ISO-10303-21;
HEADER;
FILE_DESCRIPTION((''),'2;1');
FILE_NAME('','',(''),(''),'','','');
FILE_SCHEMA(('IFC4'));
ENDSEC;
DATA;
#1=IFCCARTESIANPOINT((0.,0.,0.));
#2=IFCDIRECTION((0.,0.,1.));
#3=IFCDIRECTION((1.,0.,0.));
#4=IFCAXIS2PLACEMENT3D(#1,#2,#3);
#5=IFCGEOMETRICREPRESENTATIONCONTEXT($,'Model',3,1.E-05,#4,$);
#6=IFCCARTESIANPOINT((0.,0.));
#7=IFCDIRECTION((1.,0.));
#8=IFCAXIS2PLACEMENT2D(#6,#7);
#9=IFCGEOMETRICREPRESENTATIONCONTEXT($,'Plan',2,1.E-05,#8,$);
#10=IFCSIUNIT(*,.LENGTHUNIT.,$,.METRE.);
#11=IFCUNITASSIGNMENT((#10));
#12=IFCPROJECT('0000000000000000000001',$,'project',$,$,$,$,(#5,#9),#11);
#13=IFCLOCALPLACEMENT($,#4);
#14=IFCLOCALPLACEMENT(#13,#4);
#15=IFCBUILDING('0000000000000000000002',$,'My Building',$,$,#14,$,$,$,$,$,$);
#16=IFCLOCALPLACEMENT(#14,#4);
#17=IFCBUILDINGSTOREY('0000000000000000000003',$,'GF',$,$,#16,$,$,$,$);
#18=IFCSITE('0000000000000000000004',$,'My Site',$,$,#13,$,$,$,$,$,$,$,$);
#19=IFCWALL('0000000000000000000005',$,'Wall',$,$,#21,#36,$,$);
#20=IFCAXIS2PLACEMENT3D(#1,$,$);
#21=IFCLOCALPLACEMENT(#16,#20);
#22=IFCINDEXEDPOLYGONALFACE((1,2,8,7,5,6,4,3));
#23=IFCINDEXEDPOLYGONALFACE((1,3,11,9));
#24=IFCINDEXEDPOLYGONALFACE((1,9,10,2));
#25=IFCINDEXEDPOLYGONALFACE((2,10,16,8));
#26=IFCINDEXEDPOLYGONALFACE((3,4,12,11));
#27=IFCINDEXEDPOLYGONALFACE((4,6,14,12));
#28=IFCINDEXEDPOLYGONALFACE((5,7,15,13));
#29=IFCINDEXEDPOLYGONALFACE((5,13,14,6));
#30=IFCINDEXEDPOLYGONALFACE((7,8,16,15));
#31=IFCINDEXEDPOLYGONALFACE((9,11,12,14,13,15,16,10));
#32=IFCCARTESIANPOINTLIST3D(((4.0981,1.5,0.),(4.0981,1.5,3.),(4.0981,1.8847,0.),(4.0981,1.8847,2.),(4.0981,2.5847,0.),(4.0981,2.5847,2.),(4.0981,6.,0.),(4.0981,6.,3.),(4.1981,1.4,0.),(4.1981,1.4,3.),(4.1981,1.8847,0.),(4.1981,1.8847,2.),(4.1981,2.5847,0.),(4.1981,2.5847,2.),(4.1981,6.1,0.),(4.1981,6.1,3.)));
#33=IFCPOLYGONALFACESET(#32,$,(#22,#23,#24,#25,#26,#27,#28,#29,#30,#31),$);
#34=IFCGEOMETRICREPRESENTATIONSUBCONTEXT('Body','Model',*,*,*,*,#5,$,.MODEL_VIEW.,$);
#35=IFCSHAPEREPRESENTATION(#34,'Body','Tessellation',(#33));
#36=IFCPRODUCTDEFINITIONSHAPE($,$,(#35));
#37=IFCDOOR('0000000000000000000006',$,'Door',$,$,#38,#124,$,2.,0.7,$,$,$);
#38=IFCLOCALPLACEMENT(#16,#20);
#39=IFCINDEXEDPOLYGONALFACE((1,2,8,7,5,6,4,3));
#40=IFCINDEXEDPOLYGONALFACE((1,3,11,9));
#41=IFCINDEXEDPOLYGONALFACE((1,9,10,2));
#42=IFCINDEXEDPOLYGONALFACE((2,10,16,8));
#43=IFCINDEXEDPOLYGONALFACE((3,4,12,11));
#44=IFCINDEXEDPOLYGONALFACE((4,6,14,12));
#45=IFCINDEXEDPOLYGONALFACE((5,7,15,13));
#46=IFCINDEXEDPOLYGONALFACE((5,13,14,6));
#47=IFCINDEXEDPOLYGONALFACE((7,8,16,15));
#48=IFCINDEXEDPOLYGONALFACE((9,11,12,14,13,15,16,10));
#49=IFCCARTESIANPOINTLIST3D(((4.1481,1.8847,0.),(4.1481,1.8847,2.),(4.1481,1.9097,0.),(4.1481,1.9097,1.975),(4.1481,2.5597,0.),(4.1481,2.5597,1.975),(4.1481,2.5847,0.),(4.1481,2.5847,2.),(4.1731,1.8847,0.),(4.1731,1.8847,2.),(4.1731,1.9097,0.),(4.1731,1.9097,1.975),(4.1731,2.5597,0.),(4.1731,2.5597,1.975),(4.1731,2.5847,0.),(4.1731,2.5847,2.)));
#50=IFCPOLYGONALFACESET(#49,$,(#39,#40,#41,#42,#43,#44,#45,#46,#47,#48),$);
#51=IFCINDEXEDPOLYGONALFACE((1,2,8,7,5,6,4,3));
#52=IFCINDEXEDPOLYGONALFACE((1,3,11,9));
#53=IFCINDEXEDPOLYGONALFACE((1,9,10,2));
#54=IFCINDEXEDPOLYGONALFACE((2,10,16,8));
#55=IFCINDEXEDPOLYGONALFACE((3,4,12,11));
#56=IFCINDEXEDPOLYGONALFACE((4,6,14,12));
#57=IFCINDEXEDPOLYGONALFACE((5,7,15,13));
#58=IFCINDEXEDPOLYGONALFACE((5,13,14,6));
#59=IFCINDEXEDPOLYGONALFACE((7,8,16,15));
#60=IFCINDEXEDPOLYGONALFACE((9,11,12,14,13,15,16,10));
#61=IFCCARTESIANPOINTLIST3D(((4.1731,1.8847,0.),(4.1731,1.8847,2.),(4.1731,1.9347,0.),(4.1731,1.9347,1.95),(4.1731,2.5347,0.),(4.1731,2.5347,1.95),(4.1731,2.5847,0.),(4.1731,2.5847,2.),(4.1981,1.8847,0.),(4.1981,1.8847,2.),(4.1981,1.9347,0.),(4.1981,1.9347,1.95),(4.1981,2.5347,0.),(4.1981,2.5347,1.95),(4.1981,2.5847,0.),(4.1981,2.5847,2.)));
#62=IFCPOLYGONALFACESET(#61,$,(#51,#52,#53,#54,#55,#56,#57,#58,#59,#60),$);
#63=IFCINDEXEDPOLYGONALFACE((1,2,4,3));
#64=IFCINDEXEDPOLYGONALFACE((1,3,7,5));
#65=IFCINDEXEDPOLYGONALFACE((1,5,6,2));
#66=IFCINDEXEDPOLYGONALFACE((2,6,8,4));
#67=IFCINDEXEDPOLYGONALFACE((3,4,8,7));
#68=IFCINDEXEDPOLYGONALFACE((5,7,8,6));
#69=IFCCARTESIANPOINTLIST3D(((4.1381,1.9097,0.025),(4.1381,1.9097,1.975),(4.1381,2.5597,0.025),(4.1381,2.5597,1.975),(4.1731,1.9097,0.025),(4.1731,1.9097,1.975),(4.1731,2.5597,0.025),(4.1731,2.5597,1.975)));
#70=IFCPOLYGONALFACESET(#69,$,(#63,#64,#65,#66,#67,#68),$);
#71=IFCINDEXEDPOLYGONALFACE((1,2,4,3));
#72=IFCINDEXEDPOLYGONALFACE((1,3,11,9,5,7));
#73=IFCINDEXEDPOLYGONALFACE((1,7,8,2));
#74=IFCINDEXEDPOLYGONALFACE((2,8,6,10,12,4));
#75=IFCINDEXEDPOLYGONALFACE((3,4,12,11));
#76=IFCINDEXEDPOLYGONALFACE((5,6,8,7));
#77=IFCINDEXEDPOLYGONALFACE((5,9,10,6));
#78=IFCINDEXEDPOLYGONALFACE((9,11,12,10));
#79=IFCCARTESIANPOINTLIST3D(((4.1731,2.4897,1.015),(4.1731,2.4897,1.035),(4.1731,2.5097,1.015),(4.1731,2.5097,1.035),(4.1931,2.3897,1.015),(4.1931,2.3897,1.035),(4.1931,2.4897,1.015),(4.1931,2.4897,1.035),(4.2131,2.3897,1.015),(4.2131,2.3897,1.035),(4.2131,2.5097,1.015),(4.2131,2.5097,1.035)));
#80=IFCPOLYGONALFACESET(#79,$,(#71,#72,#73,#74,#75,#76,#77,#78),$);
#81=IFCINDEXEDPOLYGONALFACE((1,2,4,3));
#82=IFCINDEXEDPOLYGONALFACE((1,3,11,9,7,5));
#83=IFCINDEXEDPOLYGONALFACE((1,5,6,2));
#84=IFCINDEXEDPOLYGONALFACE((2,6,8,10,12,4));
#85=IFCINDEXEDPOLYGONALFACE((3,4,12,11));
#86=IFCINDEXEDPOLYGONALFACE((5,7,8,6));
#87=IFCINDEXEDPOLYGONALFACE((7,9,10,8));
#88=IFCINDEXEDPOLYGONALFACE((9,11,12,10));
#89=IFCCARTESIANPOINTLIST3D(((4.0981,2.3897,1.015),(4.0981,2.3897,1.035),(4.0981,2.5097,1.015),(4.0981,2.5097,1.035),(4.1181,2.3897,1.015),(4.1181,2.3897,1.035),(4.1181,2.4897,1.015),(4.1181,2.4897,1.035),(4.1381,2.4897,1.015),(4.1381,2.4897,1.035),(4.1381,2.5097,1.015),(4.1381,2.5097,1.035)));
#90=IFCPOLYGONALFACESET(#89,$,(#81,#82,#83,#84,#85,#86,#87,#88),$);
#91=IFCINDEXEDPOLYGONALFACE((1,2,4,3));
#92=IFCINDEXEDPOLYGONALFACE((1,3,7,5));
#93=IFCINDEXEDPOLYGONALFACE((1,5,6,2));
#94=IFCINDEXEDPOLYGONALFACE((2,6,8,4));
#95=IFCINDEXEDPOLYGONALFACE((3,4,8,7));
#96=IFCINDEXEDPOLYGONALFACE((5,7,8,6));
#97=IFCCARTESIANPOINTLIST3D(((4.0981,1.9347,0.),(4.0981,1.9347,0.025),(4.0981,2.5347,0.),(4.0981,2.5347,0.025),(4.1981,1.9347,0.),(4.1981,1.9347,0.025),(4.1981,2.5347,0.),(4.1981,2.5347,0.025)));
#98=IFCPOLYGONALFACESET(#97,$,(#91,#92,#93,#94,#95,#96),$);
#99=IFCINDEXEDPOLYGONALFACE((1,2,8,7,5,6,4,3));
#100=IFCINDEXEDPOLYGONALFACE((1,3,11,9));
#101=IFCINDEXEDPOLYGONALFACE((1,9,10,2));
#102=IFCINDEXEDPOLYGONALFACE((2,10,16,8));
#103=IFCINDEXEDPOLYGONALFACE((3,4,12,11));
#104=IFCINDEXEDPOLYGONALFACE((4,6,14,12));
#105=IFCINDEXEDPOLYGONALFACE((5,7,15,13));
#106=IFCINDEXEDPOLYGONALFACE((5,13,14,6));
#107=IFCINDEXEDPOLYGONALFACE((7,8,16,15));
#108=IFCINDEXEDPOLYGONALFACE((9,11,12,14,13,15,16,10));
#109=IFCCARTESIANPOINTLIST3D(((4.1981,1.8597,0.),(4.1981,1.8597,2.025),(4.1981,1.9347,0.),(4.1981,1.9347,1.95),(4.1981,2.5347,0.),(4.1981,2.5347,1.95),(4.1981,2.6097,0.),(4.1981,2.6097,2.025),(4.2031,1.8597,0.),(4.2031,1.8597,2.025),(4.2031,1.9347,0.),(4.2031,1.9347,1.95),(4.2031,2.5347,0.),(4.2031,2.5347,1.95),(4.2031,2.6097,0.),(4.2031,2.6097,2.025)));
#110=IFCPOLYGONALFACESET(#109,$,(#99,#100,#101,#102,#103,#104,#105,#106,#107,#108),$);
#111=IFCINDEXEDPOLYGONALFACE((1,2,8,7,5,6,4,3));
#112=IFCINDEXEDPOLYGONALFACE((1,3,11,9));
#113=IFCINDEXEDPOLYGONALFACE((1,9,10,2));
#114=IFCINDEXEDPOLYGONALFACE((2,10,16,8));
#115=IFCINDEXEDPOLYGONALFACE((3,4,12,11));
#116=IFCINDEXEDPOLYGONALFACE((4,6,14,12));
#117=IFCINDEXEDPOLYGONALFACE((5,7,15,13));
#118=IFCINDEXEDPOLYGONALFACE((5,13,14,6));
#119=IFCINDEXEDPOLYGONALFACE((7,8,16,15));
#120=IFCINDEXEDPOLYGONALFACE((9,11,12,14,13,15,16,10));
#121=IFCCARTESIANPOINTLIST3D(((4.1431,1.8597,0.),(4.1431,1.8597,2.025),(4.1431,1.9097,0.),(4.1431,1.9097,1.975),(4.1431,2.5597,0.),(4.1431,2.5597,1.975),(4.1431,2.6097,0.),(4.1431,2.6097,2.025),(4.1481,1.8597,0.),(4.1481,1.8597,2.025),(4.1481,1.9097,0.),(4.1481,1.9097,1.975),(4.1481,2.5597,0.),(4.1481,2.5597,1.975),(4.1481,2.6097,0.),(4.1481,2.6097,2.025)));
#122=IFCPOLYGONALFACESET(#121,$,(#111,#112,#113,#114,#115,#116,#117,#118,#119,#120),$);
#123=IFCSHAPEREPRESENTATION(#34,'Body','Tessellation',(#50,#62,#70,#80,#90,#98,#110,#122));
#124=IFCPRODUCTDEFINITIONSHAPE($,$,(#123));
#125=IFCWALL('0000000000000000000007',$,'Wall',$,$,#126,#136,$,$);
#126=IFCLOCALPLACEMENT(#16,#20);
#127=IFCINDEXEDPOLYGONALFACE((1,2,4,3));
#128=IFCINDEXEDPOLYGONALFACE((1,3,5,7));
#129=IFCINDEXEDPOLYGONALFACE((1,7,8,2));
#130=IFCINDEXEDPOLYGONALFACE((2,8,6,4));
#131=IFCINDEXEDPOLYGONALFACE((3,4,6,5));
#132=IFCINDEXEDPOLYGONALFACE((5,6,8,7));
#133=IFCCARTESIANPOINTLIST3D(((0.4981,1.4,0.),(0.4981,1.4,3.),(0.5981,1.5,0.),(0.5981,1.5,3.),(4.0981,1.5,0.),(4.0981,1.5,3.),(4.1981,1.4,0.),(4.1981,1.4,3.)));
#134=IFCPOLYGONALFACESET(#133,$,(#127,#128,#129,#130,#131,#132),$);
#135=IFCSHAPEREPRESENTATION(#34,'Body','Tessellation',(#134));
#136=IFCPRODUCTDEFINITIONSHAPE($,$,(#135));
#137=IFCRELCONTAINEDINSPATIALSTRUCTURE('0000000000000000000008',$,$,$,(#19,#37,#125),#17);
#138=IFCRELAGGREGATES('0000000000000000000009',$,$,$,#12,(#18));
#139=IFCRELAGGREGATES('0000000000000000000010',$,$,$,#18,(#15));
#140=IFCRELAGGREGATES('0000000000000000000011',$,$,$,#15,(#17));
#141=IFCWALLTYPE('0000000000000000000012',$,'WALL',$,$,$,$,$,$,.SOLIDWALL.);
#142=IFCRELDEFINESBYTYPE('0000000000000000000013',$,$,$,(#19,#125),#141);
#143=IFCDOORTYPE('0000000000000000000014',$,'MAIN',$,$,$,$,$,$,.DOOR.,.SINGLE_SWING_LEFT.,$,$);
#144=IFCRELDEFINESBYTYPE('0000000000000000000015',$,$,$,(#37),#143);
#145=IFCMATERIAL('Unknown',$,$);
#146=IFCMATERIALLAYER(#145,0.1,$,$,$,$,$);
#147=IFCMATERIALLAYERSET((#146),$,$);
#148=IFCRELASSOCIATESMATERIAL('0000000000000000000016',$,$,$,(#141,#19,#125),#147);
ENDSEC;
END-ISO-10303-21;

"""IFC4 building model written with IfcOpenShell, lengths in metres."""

from ifc_helpers import new_model, entity, si_unit, frame, origin_with_axes, origin_2d_with_axis, place, context, subcontext, project, spatial, line, indexed_curve, outline, extrude, shape, source, transform, mapped, material, layer, layer_set, layer_usage, type_object, type_shapes, element, fill, save


model = new_model("IFC4")

# Units and contexts
model_context = context("Model", 3, precision=1e-05, world=origin_with_axes())
plan_context = context("Plan", 2, precision=1e-05, world=origin_2d_with_axis())
body_context_1 = subcontext(model_context, "Body", "Model", "MODEL_VIEW")
body_context_2 = subcontext(plan_context, "Body", "Plan", "PLAN_VIEW")
ifc_project = project(units=[si_unit("LENGTHUNIT", "METRE")], contexts=[model_context, plan_context])

# Site, building, storey
site_placement = place(None, origin_with_axes())
site = spatial("IfcSite", under=ifc_project, at=site_placement, Name="My Site")
building_placement = place(site_placement, origin_with_axes())
building = spatial("IfcBuilding", under=site, at=building_placement, Name="My Building")
storey_placement = place(building_placement, origin_with_axes())
storey = spatial("IfcBuildingStorey", under=building, at=storey_placement, Name="GF")

# Shared definitions
ifc_material = material(Name="Unknown")

# Shared definitions
ifc_layer_1 = layer(ifc_material, 0.1)
ifc_layer_set_1 = layer_set([ifc_layer_1])
wall_type_1 = type_object("IfcWallType", Name="WALL", PredefinedType="SOLIDWALL", material=ifc_layer_set_1)

# Wall, opening, door
ifc_layer_usage_1 = layer_usage(ifc_layer_set_1, "AXIS2", "POSITIVE", 0.0)
wall_1_placement = place(storey_placement, frame((4.0981, 6.0, 0.0), z_axis=(0.0, 0.0, 1.0), x_axis=(0.0, -1.0, 0.0)))
wall_1 = element("IfcWall", 1, at=wall_1_placement, inside=storey, type_object=wall_type_1, material=ifc_layer_usage_1, Name="Wall", context=body_context_1, shape_type="SweptSolid", body=[
    extrude(outline(indexed_curve([(0.0, 0.0), (-0.1, 0.1), (4.6, 0.1), (4.5, 0.0)], segments=[line(1, 2, 3, 4, 1)])), origin_with_axes(), (0.0, 0.0, 1.0), 3.0),
])
shared_shape_1 = source(origin_with_axes(), body_context_1, "Body", "SweptSolid", [
    extrude(outline(indexed_curve([(0.0, 0.0), (0.7, 0.0), (0.7, 2.0), (0.0, 2.0)], segments=[line(1, 2, 3, 4, 1)])), frame((0.0, -0.6, 0.0), z_axis=(0.0, -1.0, 0.0), x_axis=(1.0, 0.0, 0.0)), (0.0, 0.0, -1.0), 1.2),
])
opening_1_placement = place(wall_1_placement, frame((4.1153, 0.1, 0.0), z_axis=(0.0, 0.0, 1.0), x_axis=(-1.0, 0.0, 0.0)))
opening_1 = element("IfcOpeningElement", 2, at=opening_1_placement, cuts=wall_1, PredefinedType="OPENING", context=body_context_1, shape_type="MappedRepresentation", body=[
    mapped(shared_shape_1, transform((0.0, 0.0, 0.0), x_axis=(1.0, 0.0, 0.0), y_axis=(0.0, 1.0, 0.0), z_axis=(0.0, 0.0, 1.0), scale=1.0)),
])
door_type_1 = type_object("IfcDoorType", Name="MAIN", OperationType="SINGLE_SWING_LEFT", PredefinedType="DOOR")
shared_shape_2 = source(origin_with_axes(), body_context_1, "Body", "SweptSolid", [
    extrude(outline(indexed_curve([(0.0, 0.0), (0.0, 2.0), (0.7, 2.0), (0.7, 0.0), (0.675, 0.0), (0.675, 1.975), (0.025, 1.975), (0.025, 0.0)], segments=[line(1, 2, 3, 4, 5, 6, 7, 8, 1)])), frame((0.0, 0.025, 0.0), z_axis=(0.0, -1.0, 0.0), x_axis=(1.0, 0.0, 0.0)), (0.0, 0.0, -1.0), 0.025),
    extrude(outline(indexed_curve([(0.0, 0.0), (0.0, 2.0), (0.7, 2.0), (0.7, 0.0), (0.65, 0.0), (0.65, 1.95), (0.05, 1.95), (0.05, 0.0)], segments=[line(1, 2, 3, 4, 5, 6, 7, 8, 1)])), frame((0.0, 0.0, 0.0), z_axis=(0.0, -1.0, 0.0), x_axis=(1.0, 0.0, 0.0)), (0.0, 0.0, -1.0), 0.025),
    extrude(outline(indexed_curve([(0.0, 0.0), (0.65, 0.0), (0.65, 0.035), (0.0, 0.035)], segments=[line(1, 2, 3, 4, 1)])), frame((0.025, 0.025, 0.025), z_axis=(0.0, 0.0, 1.0), x_axis=(1.0, 0.0, 0.0)), (0.0, 0.0, 1.0), 1.95),
    extrude(outline(indexed_curve([(0.0, 0.0), (0.0, -0.04), (-0.12, -0.04), (-0.12, -0.02), (-0.02, -0.02), (-0.02, 0.0)], segments=[line(1, 2, 3, 4, 5, 6, 1)])), frame((0.625, 0.025, 1.015), z_axis=(0.0, 0.0, 1.0), x_axis=(1.0, 0.0, 0.0)), (0.0, 0.0, 1.0), 0.02),
    extrude(outline(indexed_curve([(0.0, 0.0), (0.0, 0.04), (-0.12, 0.04), (-0.12, 0.02), (-0.02, 0.02), (-0.02, 0.0)], segments=[line(1, 2, 3, 4, 5, 6, 1)])), frame((0.625, 0.06, 1.015), z_axis=(0.0, 0.0, 1.0), x_axis=(1.0, 0.0, 0.0)), (0.0, 0.0, 1.0), 0.02),
    extrude(outline(indexed_curve([(0.0, 0.0), (0.6, 0.0), (0.6, 0.1), (0.0, 0.1)], segments=[line(1, 2, 3, 4, 1)])), frame((0.05, 0.0, 0.0), z_axis=(0.0, 0.0, 1.0), x_axis=(1.0, 0.0, 0.0)), (0.0, 0.0, 1.0), 0.025),
    extrude(outline(indexed_curve([(0.0, 0.0), (0.0, 2.025), (0.75, 2.025), (0.75, 0.0), (0.675, 0.0), (0.675, 1.95), (0.075, 1.95), (0.075, 0.0)], segments=[line(1, 2, 3, 4, 5, 6, 7, 8, 1)])), frame((-0.025, -0.005, 0.0), z_axis=(0.0, -1.0, 0.0), x_axis=(1.0, 0.0, 0.0)), (0.0, 0.0, -1.0), 0.005),
    extrude(outline(indexed_curve([(0.0, 0.0), (0.0, 2.025), (0.75, 2.025), (0.75, 0.0), (0.7, 0.0), (0.7, 1.975), (0.05, 1.975), (0.05, 0.0)], segments=[line(1, 2, 3, 4, 5, 6, 7, 8, 1)])), frame((-0.025, 0.05, 0.0), z_axis=(0.0, -1.0, 0.0), x_axis=(1.0, 0.0, 0.0)), (0.0, 0.0, -1.0), 0.005),
])
shared_shape_3 = source(origin_with_axes(), body_context_2, "Body", "Curve2D", [
    entity("IfcIndexedPolyCurve", entity("IfcCartesianPointList2D", [[0.0, 0.0], [0.0, 0.05], [0.025, 0.05], [0.025, 0.025], [0.05, 0.025], [0.05, 0.0]]), [entity("IfcLineIndex", [1, 2, 3, 4, 5, 6, 1])]),
    entity("IfcIndexedPolyCurve", entity("IfcCartesianPointList2D", [[0.7, 0.0], [0.7, 0.05], [0.675, 0.05], [0.675, 0.025], [0.65, 0.025], [0.65, 0.0]]), [entity("IfcLineIndex", [1, 2, 3, 4, 5, 6, 1])]),
    entity("IfcTrimmedCurve", entity("IfcEllipse", entity("IfcAxis2Placement2D", entity("IfcCartesianPoint", [0.06, 0.05]), entity("IfcDirection", [1.0, 0.0])), 0.615, 0.65), [entity("IfcCartesianPoint", [0.675, 0.05])], [entity("IfcCartesianPoint", [0.06, 0.7])], True, "CARTESIAN"),
    entity("IfcIndexedPolyCurve", entity("IfcCartesianPointList2D", [[0.025, 0.05], [0.06, 0.05], [0.06, 0.7], [0.025, 0.7]]), [entity("IfcLineIndex", [1, 2, 3, 4, 1])]),
])
type_shapes(door_type_1, [shared_shape_2, shared_shape_3])
door_1_placement = place(opening_1_placement, frame((0.0, 0.0, 0.0), z_axis=(0.0, 0.0, 1.0), x_axis=(1.0, 0.0, 0.0)))
door_1 = element("IfcDoor", 3, at=door_1_placement, inside=storey, type_object=door_type_1, Name="Door", OverallHeight=2.0, OverallWidth=0.7, shapes=[
    shape(body_context_1, "Body", "MappedRepresentation", [mapped(shared_shape_2, transform((0.0, 0.0, 0.0), x_axis=(1.0, 0.0, 0.0), y_axis=(0.0, 1.0, 0.0), z_axis=(0.0, 0.0, 1.0), scale=1.0))]),
    shape(body_context_2, "Body", "MappedRepresentation", [mapped(shared_shape_3, transform((0.0, 0.0, 0.0), x_axis=(1.0, 0.0, 0.0), y_axis=(0.0, 1.0, 0.0), z_axis=(0.0, 0.0, 1.0), scale=1.0))]),
])
fill(opening_1, door_1)

# Wall
ifc_layer_usage_2 = layer_usage(ifc_layer_set_1, "AXIS2", "POSITIVE", 0.0)
wall_2_placement = place(storey_placement, frame((4.0981, 1.5, 0.0), z_axis=(0.0, 0.0, 1.0), x_axis=(-1.0, 0.0, 0.0)))
element("IfcWall", 4, at=wall_2_placement, inside=storey, type_object=wall_type_1, material=ifc_layer_usage_2, Name="Wall", context=body_context_1, shape_type="SweptSolid", body=[
    extrude(outline(indexed_curve([(0.0, 0.0), (-0.1, 0.1), (3.6, 0.1), (3.5, 0.0)], segments=[line(1, 2, 3, 4, 1)])), origin_with_axes(), (0.0, 0.0, 1.0), 3.0),
])

save(model, "model.ifc")
